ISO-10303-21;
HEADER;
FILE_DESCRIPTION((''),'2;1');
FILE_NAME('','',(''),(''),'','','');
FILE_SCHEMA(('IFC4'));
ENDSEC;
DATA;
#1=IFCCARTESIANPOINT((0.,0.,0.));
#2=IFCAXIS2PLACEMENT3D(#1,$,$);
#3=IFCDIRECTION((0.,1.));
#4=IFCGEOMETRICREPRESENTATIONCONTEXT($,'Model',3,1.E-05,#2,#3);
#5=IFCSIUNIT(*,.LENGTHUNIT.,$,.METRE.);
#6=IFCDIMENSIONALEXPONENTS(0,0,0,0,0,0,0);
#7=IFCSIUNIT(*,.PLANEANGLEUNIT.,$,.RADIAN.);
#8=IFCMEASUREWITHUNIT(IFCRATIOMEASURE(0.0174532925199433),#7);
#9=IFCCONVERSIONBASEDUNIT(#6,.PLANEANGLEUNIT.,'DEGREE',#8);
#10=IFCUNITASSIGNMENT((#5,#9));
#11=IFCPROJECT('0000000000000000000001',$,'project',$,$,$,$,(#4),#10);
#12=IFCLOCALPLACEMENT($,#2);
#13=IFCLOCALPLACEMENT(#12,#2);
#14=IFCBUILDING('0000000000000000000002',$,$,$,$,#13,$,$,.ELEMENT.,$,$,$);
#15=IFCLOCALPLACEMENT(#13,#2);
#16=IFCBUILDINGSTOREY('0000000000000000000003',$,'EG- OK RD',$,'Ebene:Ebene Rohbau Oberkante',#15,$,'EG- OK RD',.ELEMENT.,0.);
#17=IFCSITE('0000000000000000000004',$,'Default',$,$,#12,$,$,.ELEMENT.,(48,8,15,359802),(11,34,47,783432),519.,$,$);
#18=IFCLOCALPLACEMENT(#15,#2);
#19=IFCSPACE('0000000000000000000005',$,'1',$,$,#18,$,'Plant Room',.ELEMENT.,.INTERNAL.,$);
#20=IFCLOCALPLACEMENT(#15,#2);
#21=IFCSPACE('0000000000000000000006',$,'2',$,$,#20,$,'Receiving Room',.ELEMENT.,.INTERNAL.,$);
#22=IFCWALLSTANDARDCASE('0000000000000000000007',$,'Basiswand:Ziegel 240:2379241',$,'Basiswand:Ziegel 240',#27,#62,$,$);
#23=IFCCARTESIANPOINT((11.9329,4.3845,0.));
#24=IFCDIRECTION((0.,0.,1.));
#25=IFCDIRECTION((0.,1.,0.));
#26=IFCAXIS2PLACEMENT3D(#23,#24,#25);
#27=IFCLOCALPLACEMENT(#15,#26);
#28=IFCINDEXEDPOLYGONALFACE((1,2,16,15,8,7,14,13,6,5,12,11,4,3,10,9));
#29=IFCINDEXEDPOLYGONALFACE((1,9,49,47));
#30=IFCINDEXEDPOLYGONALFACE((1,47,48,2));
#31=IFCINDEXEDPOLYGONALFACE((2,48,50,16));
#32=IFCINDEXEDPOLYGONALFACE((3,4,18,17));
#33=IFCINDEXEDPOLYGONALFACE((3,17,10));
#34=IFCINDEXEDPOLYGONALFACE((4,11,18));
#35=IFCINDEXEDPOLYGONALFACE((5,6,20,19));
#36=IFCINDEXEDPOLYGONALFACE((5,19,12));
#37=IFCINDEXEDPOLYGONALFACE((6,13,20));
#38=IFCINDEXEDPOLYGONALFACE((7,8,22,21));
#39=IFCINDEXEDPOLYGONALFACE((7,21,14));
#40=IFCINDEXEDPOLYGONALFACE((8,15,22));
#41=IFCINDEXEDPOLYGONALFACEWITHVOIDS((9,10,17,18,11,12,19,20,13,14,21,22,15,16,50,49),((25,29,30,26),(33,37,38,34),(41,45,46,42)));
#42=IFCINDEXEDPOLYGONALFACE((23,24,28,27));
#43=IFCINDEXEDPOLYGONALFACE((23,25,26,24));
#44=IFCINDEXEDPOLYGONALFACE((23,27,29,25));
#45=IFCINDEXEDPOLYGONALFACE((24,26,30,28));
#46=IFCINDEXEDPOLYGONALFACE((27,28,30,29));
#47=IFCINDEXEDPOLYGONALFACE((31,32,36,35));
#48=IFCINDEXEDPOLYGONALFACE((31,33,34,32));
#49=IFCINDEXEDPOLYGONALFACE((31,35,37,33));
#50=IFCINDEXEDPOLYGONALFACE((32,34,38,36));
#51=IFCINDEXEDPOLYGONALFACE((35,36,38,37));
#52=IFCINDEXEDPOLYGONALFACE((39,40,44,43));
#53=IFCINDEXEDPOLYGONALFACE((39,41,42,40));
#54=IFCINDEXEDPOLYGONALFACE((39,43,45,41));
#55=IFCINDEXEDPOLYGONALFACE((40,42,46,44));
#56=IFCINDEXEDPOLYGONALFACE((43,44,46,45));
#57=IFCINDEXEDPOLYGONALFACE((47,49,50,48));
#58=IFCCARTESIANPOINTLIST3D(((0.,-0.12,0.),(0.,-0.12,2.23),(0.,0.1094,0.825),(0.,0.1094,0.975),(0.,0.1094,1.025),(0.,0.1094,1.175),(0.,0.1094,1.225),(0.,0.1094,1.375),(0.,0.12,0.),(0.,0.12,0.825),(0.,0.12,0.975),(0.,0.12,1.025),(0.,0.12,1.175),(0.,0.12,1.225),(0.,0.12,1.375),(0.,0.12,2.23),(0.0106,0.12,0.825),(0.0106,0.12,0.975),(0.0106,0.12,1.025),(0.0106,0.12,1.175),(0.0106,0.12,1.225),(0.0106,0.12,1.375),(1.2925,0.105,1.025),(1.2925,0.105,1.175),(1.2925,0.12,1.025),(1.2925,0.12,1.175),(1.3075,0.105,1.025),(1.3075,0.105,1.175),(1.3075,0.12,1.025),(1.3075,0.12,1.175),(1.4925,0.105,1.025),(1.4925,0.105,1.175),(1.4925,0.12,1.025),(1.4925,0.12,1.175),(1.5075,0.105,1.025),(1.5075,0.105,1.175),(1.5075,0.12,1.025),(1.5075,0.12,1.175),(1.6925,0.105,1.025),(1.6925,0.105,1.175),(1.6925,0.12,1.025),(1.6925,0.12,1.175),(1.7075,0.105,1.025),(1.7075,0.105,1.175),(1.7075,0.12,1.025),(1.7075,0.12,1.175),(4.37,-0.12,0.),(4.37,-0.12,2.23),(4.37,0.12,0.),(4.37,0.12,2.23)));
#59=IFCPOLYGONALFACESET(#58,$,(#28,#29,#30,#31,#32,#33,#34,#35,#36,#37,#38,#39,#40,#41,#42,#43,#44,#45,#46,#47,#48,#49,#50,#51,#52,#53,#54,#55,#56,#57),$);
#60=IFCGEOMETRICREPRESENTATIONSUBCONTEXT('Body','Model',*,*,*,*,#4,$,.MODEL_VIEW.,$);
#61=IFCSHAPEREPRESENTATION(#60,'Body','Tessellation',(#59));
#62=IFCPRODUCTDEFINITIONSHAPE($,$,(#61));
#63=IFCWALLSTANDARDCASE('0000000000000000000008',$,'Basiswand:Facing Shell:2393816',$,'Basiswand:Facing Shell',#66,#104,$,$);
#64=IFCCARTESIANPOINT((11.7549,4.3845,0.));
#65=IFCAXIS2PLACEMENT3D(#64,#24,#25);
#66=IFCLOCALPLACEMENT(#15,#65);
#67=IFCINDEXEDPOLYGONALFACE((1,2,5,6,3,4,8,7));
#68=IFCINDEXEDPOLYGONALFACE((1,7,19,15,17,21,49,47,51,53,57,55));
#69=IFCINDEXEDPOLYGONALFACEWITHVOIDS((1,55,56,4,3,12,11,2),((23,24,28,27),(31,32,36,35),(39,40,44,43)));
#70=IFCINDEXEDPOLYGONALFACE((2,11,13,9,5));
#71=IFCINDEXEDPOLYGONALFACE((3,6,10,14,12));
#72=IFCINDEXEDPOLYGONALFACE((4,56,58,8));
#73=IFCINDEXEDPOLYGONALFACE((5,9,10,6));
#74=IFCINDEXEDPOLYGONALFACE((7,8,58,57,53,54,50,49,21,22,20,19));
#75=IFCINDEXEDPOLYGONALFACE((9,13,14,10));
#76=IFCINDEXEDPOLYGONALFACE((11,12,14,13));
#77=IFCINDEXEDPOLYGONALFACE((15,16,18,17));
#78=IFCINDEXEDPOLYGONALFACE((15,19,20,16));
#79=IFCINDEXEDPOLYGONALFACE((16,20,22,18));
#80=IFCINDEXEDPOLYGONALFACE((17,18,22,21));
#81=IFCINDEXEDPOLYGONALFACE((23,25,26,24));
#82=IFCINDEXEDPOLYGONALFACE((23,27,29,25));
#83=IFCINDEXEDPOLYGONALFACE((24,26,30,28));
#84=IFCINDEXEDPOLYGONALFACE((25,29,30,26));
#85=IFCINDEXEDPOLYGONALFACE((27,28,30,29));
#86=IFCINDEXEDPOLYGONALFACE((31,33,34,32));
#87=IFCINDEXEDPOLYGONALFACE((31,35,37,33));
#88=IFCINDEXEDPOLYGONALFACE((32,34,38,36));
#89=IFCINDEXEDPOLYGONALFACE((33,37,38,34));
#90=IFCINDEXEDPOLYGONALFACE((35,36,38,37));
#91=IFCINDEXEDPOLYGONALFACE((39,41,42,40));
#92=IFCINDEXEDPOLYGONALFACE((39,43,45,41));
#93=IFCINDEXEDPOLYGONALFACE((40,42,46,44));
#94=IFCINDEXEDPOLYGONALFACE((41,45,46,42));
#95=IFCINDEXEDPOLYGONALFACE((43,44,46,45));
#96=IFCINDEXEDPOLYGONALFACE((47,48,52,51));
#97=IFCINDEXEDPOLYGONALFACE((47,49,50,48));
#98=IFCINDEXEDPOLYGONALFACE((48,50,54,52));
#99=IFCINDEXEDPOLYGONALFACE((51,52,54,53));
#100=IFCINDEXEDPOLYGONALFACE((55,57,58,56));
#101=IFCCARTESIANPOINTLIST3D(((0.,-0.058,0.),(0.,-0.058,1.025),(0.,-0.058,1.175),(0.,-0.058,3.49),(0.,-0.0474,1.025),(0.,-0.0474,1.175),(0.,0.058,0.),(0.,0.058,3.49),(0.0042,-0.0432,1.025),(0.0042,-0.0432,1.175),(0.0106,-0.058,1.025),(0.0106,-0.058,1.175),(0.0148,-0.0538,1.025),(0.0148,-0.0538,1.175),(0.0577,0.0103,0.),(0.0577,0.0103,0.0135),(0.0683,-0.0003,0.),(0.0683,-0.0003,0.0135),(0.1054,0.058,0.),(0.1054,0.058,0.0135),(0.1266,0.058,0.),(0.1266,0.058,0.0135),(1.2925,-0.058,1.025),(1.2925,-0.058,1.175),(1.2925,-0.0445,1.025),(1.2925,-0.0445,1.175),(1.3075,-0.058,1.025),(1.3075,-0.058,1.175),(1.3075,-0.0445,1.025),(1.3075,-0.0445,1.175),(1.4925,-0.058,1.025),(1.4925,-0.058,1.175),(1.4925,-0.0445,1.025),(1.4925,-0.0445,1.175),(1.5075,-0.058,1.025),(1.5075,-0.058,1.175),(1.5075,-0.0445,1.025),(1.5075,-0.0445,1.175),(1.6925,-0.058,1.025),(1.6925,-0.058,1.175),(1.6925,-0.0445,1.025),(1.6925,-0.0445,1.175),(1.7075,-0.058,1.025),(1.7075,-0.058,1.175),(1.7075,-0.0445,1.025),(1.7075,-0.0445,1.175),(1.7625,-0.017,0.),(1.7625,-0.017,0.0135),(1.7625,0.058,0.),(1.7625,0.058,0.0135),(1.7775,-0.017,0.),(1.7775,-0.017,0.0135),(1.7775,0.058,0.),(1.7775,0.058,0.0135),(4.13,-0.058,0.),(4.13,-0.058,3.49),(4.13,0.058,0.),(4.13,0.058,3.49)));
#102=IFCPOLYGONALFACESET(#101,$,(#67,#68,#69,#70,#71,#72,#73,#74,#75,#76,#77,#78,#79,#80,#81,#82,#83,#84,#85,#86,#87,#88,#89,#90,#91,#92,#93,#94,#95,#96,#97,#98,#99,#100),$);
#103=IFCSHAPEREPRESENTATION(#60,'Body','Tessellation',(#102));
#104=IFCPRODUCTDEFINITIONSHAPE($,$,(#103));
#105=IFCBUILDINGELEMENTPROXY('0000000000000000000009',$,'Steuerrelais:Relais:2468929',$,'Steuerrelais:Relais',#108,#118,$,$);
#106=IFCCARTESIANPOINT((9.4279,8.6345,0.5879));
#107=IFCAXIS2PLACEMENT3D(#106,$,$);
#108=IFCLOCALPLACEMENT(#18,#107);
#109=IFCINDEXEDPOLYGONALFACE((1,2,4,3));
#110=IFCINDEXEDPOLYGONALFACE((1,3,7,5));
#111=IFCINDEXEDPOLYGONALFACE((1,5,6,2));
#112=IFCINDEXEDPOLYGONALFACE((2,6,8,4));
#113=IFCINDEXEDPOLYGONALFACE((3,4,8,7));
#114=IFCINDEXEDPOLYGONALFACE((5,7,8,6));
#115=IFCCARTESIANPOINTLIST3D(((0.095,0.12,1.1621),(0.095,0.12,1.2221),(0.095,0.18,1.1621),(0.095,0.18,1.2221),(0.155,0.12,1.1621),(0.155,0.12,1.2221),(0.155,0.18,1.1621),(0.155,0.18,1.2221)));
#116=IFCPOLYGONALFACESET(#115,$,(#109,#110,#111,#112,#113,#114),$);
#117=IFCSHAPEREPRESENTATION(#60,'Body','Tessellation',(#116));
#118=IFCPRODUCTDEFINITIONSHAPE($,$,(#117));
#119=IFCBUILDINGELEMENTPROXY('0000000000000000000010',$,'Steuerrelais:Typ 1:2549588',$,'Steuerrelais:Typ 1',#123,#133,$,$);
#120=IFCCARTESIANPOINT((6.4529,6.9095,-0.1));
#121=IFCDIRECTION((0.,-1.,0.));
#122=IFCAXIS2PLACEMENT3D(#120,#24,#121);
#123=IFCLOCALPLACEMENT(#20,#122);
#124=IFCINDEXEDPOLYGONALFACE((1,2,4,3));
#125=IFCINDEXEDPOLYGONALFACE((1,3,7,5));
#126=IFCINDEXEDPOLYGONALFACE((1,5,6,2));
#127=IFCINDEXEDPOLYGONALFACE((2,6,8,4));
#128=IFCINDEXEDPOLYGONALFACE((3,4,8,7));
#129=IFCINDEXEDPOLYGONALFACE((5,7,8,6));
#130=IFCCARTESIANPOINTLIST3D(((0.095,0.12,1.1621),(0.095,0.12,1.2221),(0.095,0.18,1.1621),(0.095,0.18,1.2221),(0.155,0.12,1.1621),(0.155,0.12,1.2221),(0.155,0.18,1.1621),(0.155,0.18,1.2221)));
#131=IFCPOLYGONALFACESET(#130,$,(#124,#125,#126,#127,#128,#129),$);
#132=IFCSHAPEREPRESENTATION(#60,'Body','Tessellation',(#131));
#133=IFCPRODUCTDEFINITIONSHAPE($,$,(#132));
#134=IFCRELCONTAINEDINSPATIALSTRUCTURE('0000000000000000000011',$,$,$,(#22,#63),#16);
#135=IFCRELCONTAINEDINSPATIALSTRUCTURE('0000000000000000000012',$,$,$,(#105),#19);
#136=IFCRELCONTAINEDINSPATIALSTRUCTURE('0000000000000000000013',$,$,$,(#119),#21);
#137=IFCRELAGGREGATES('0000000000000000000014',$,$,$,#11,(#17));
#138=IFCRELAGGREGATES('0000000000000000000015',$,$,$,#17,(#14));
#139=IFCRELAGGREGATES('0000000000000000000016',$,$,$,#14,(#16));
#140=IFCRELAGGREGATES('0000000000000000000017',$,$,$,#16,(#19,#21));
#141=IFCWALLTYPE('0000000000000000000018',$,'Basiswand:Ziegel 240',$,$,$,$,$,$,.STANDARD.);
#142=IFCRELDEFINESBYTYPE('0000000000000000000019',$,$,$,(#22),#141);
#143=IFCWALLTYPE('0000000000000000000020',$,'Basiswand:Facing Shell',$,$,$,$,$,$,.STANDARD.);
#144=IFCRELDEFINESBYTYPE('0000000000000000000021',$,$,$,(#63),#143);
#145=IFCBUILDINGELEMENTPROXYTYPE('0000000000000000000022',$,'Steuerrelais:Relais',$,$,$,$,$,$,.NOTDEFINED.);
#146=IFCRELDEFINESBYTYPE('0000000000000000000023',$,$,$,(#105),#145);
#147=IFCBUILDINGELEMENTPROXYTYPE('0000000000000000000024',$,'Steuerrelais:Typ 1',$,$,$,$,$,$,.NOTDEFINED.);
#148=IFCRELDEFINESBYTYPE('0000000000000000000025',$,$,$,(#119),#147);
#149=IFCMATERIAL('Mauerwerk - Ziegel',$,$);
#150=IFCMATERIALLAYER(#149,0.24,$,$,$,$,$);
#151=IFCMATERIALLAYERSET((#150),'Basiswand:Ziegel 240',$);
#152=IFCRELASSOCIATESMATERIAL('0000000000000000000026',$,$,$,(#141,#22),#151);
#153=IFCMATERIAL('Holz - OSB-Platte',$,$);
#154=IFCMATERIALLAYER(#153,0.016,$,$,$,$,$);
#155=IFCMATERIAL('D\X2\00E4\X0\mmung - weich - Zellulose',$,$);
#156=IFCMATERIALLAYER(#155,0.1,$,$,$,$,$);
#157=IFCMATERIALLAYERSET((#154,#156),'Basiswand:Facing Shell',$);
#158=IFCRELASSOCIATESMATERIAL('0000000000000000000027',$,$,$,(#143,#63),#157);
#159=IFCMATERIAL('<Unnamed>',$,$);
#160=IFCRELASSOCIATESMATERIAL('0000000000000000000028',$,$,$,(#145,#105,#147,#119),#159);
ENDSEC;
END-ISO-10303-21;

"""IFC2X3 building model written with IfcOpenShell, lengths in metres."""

from ifc_helpers import new_model, entity, si_unit, converted_unit, direction, frame, frame_2d, origin, origin_2d_with_axis, place, context, subcontext, project, spatial, rectangle, extrude, source, transform, mapped, material, layer, layer_set, layer_usage, type_object, type_shapes, element, save


model = new_model("IFC2X3")

# Units and contexts
model_context = context("Model", 3, precision=1e-05, world=origin(), true_north=direction((0.0, 1.0)))
body_context = subcontext(model_context, "Body", "Model", "MODEL_VIEW")
ifc_project = project(units=[si_unit("LENGTHUNIT", "METRE"), converted_unit("PLANEANGLEUNIT", "DEGREE", entity("IfcRatioMeasure", 0.0174532925199433), si_unit("PLANEANGLEUNIT", "RADIAN"), dimensions=[0, 0, 0, 0, 0, 0, 0])], contexts=[model_context])

# Site, building, storey
site_placement = place(None, origin())
site = spatial("IfcSite", under=ifc_project, at=site_placement, Name="Default", CompositionType="ELEMENT", RefLatitude=(48, 8, 15, 359802), RefLongitude=(11, 34, 47, 783432), RefElevation=519.0)
building_placement = place(site_placement, origin())
building = spatial("IfcBuilding", under=site, at=building_placement, CompositionType="ELEMENT")
storey_placement = place(building_placement, origin())
storey = spatial("IfcBuildingStorey", under=building, at=storey_placement, Name="EG- OK RD", ObjectType="Ebene:Ebene Rohbau Oberkante", LongName="EG- OK RD", CompositionType="ELEMENT", Elevation=0.0)

# Wall, openings
ifc_material_1 = material(Name="Mauerwerk - Ziegel")
ifc_layer_1 = layer(ifc_material_1, 0.24)
ifc_layer_set_1 = layer_set([ifc_layer_1], Name="Basiswand:Ziegel 240")
ifc_layer_usage_1 = layer_usage(ifc_layer_set_1, "AXIS2", "POSITIVE", -0.12)
wall_type_1 = type_object("IfcWallType", Name="Basiswand:Ziegel 240", PredefinedType="STANDARD", material=ifc_layer_set_1)
wall_1_placement = place(storey_placement, frame((11.9329, 4.3845, 0.0), z_axis=(0.0, 0.0, 1.0), x_axis=(0.0, 1.0, 0.0)))
wall_1 = element("IfcWallStandardCase", 1, at=wall_1_placement, inside=storey, type_object=wall_type_1, material=ifc_layer_usage_1, Name="Basiswand:Ziegel 240:2379241", ObjectType="Basiswand:Ziegel 240", context=body_context, shape_type="SweptSolid", body=[
    extrude(rectangle(XDim=4.37, YDim=0.24, at=frame_2d((2.185, 0.0), x_axis=(-1.0, 0.0))), origin(), (0.0, 0.0, 1.0), 2.23),
])
opening_1_placement = place(wall_1_placement, origin())
element("IfcOpeningElement", 2, at=opening_1_placement, cuts=wall_1, ObjectType="Recess", context=body_context, shape_type="SweptSolid", body=[
    extrude(rectangle(XDim=0.15, YDim=0.0285, at=frame_2d((0.0, 0.0), x_axis=(0.0, 1.0))), frame((0.0048, 0.1142, 1.1), z_axis=(-0.707107, 0.707107, 0.0), x_axis=(-0.707107, -0.707107, 0.0)), (0.0, 0.0, 1.0), 0.015),
])
opening_2_placement = place(wall_1_placement, origin())
element("IfcOpeningElement", 3, at=opening_2_placement, cuts=wall_1, ObjectType="Recess", context=body_context, shape_type="SweptSolid", body=[
    extrude(rectangle(XDim=0.15, YDim=0.0285, at=frame_2d((0.0, 0.0), x_axis=(0.0, 1.0))), frame((0.0048, 0.1142, 0.9), z_axis=(-0.707107, 0.707107, 0.0), x_axis=(-0.707107, -0.707107, 0.0)), (0.0, 0.0, 1.0), 0.015),
])
opening_3_placement = place(wall_1_placement, origin())
element("IfcOpeningElement", 4, at=opening_3_placement, cuts=wall_1, ObjectType="Recess", context=body_context, shape_type="SweptSolid", body=[
    extrude(rectangle(XDim=0.15, YDim=0.0285, at=frame_2d((0.0, 0.0), x_axis=(0.0, 1.0))), frame((0.0048, 0.1142, 1.3), z_axis=(-0.707107, 0.707107, 0.0), x_axis=(-0.707107, -0.707107, 0.0)), (0.0, 0.0, 1.0), 0.015),
])
opening_4_placement = place(wall_1_placement, origin())
element("IfcOpeningElement", 5, at=opening_4_placement, cuts=wall_1, ObjectType="Recess", context=body_context, shape_type="SweptSolid", body=[
    extrude(rectangle(XDim=0.15, YDim=0.015, at=frame_2d((0.0, 0.0), x_axis=(0.0, 1.0))), frame((1.3, 0.105, 1.1), z_axis=(0.0, 1.0, 0.0), x_axis=(-1.0, 0.0, 0.0)), (0.0, 0.0, 1.0), 0.0285),
])
opening_5_placement = place(wall_1_placement, origin())
element("IfcOpeningElement", 6, at=opening_5_placement, cuts=wall_1, ObjectType="Recess", context=body_context, shape_type="SweptSolid", body=[
    extrude(rectangle(XDim=0.15, YDim=0.015, at=frame_2d((0.0, 0.0), x_axis=(0.0, 1.0))), frame((1.5, 0.105, 1.1), z_axis=(0.0, 1.0, 0.0), x_axis=(-1.0, 0.0, 0.0)), (0.0, 0.0, 1.0), 0.0285),
])
opening_6_placement = place(wall_1_placement, origin())
element("IfcOpeningElement", 7, at=opening_6_placement, cuts=wall_1, ObjectType="Recess", context=body_context, shape_type="SweptSolid", body=[
    extrude(rectangle(XDim=0.15, YDim=0.015, at=frame_2d((0.0, 0.0), x_axis=(0.0, 1.0))), frame((1.7, 0.105, 1.1), z_axis=(0.0, 1.0, 0.0), x_axis=(-1.0, 0.0, 0.0)), (0.0, 0.0, 1.0), 0.0285),
])

# Wall, openings
ifc_material_2 = material(Name="Holz - OSB-Platte")
ifc_layer_2 = layer(ifc_material_2, 0.016)
ifc_material_3 = material(Name="Dämmung - weich - Zellulose")
ifc_layer_3 = layer(ifc_material_3, 0.1)
ifc_layer_set_2 = layer_set([ifc_layer_2, ifc_layer_3], Name="Basiswand:Facing Shell")
ifc_layer_usage_2 = layer_usage(ifc_layer_set_2, "AXIS2", "NEGATIVE", 0.058)
wall_type_2 = type_object("IfcWallType", Name="Basiswand:Facing Shell", PredefinedType="STANDARD", material=ifc_layer_set_2)
wall_2_placement = place(storey_placement, frame((11.7549, 4.3845, 0.0), z_axis=(0.0, 0.0, 1.0), x_axis=(0.0, 1.0, 0.0)))
wall_2 = element("IfcWallStandardCase", 8, at=wall_2_placement, inside=storey, type_object=wall_type_2, material=ifc_layer_usage_2, Name="Basiswand:Facing Shell:2393816", ObjectType="Basiswand:Facing Shell", context=body_context, shape_type="SweptSolid", body=[
    extrude(rectangle(XDim=4.13, YDim=0.116, at=frame_2d((2.065, 0.0), x_axis=(-1.0, 0.0))), origin(), (0.0, 0.0, 1.0), 3.49),
])
opening_7_placement = place(wall_2_placement, origin())
element("IfcOpeningElement", 9, at=opening_7_placement, cuts=wall_2, ObjectType="Recess", context=body_context, shape_type="SweptSolid", body=[
    extrude(rectangle(XDim=0.15, YDim=0.015, at=frame_2d((0.0, 0.0), x_axis=(0.0, 1.0))), frame((1.3, -0.073, 1.1), z_axis=(0.0, 1.0, 0.0), x_axis=(-1.0, 0.0, 0.0)), (0.0, 0.0, 1.0), 0.0285),
])
opening_8_placement = place(wall_2_placement, origin())
element("IfcOpeningElement", 10, at=opening_8_placement, cuts=wall_2, ObjectType="Recess", context=body_context, shape_type="SweptSolid", body=[
    extrude(rectangle(XDim=0.15, YDim=0.015, at=frame_2d((0.0, 0.0), x_axis=(0.0, 1.0))), frame((1.5, -0.073, 1.1), z_axis=(0.0, 1.0, 0.0), x_axis=(-1.0, 0.0, 0.0)), (0.0, 0.0, 1.0), 0.0285),
])
opening_9_placement = place(wall_2_placement, origin())
element("IfcOpeningElement", 11, at=opening_9_placement, cuts=wall_2, ObjectType="Recess", context=body_context, shape_type="SweptSolid", body=[
    extrude(rectangle(XDim=0.15, YDim=0.015, at=frame_2d((0.0, 0.0), x_axis=(0.0, 1.0))), frame((1.7, -0.073, 1.1), z_axis=(0.0, 1.0, 0.0), x_axis=(-1.0, 0.0, 0.0)), (0.0, 0.0, 1.0), 0.0285),
])
opening_10_placement = place(wall_2_placement, origin())
element("IfcOpeningElement", 12, at=opening_10_placement, cuts=wall_2, ObjectType="Recess", context=body_context, shape_type="SweptSolid", body=[
    extrude(rectangle(XDim=0.15, YDim=0.0285, at=frame_2d((0.0, 0.0), x_axis=(0.0, 1.0))), frame((0.0048, -0.0638, 1.1), z_axis=(-0.707107, 0.707107, 0.0), x_axis=(-0.707107, -0.707107, 0.0)), (0.0, 0.0, 1.0), 0.015),
])
opening_11_placement = place(wall_2_placement, origin())
element("IfcOpeningElement", 13, at=opening_11_placement, cuts=wall_2, ObjectType="Recess", context=body_context, shape_type="SweptSolid", body=[
    extrude(rectangle(XDim=0.0285, YDim=0.15, at=frame_2d((0.0, 0.0), x_axis=(1.0, 0.0))), frame((0.1213, 0.0527, -0.0007), z_axis=(-0.707107, 0.707107, 0.0), x_axis=(0.0, 0.0, -1.0)), (0.0, 0.0, 1.0), 0.015),
])
opening_12_placement = place(wall_2_placement, origin())
element("IfcOpeningElement", 14, at=opening_12_placement, cuts=wall_2, ObjectType="Opening", context=body_context, shape_type="SweptSolid", body=[
    extrude(rectangle(XDim=0.0285, YDim=0.015, at=frame_2d((0.0, 0.0), x_axis=(1.0, 0.0))), frame((1.77, -0.017, -0.0007), z_axis=(0.0, 1.0, 0.0), x_axis=(0.0, 0.0, -1.0)), (0.0, 0.0, 1.0), 0.15),
])

# Shared definitions
space_1_placement = place(storey_placement, origin())
space_1 = spatial("IfcSpace", under=storey, at=space_1_placement, Name="1", LongName="Plant Room", CompositionType="ELEMENT", InteriorOrExteriorSpace="INTERNAL")

# Building element proxy
ifc_material_4 = material(Name="<Unnamed>")
building_element_proxy_type_1 = type_object("IfcBuildingElementProxyType", Name="Steuerrelais:Relais", PredefinedType="NOTDEFINED", material=ifc_material_4)
shared_shape_1 = source(origin(), body_context, "Body", "SweptSolid", [
    extrude(rectangle(XDim=0.06, YDim=0.06, at=origin_2d_with_axis()), frame((0.125, 0.15, 1.1621), z_axis=(0.0, 0.0, 1.0), x_axis=(0.0, 1.0, 0.0)), (0.0, 0.0, 1.0), 0.06),
])
type_shapes(building_element_proxy_type_1, [shared_shape_1])
proxy_1_placement = place(space_1_placement, frame((9.4279, 8.6345, 0.5879)))
element("IfcBuildingElementProxy", 15, at=proxy_1_placement, inside=space_1, type_object=building_element_proxy_type_1, material=ifc_material_4, Name="Steuerrelais:Relais:2468929", ObjectType="Steuerrelais:Relais", context=body_context, shape_type="MappedRepresentation", body=[
    mapped(shared_shape_1, transform((0.0, 0.0, 0.0), scale=1.0)),
])

# Shared definitions
space_2_placement = place(storey_placement, origin())
space_2 = spatial("IfcSpace", under=storey, at=space_2_placement, Name="2", LongName="Receiving Room", CompositionType="ELEMENT", InteriorOrExteriorSpace="INTERNAL")

# Building element proxy
building_element_proxy_type_2 = type_object("IfcBuildingElementProxyType", Name="Steuerrelais:Typ 1", PredefinedType="NOTDEFINED", material=ifc_material_4)
shared_shape_2 = source(origin(), body_context, "Body", "SweptSolid", [
    extrude(rectangle(XDim=0.06, YDim=0.06, at=origin_2d_with_axis()), frame((0.125, 0.15, 1.1621), z_axis=(0.0, 0.0, 1.0), x_axis=(0.0, 1.0, 0.0)), (0.0, 0.0, 1.0), 0.06),
])
type_shapes(building_element_proxy_type_2, [shared_shape_2])
proxy_2_placement = place(space_2_placement, frame((6.4529, 6.9095, -0.1), z_axis=(0.0, 0.0, 1.0), x_axis=(0.0, -1.0, 0.0)))
element("IfcBuildingElementProxy", 16, at=proxy_2_placement, inside=space_2, type_object=building_element_proxy_type_2, material=ifc_material_4, Name="Steuerrelais:Typ 1:2549588", ObjectType="Steuerrelais:Typ 1", context=body_context, shape_type="MappedRepresentation", body=[
    mapped(shared_shape_2, transform((0.0, 0.0, 0.0), scale=1.0)),
])

save(model, "model.ifc")
